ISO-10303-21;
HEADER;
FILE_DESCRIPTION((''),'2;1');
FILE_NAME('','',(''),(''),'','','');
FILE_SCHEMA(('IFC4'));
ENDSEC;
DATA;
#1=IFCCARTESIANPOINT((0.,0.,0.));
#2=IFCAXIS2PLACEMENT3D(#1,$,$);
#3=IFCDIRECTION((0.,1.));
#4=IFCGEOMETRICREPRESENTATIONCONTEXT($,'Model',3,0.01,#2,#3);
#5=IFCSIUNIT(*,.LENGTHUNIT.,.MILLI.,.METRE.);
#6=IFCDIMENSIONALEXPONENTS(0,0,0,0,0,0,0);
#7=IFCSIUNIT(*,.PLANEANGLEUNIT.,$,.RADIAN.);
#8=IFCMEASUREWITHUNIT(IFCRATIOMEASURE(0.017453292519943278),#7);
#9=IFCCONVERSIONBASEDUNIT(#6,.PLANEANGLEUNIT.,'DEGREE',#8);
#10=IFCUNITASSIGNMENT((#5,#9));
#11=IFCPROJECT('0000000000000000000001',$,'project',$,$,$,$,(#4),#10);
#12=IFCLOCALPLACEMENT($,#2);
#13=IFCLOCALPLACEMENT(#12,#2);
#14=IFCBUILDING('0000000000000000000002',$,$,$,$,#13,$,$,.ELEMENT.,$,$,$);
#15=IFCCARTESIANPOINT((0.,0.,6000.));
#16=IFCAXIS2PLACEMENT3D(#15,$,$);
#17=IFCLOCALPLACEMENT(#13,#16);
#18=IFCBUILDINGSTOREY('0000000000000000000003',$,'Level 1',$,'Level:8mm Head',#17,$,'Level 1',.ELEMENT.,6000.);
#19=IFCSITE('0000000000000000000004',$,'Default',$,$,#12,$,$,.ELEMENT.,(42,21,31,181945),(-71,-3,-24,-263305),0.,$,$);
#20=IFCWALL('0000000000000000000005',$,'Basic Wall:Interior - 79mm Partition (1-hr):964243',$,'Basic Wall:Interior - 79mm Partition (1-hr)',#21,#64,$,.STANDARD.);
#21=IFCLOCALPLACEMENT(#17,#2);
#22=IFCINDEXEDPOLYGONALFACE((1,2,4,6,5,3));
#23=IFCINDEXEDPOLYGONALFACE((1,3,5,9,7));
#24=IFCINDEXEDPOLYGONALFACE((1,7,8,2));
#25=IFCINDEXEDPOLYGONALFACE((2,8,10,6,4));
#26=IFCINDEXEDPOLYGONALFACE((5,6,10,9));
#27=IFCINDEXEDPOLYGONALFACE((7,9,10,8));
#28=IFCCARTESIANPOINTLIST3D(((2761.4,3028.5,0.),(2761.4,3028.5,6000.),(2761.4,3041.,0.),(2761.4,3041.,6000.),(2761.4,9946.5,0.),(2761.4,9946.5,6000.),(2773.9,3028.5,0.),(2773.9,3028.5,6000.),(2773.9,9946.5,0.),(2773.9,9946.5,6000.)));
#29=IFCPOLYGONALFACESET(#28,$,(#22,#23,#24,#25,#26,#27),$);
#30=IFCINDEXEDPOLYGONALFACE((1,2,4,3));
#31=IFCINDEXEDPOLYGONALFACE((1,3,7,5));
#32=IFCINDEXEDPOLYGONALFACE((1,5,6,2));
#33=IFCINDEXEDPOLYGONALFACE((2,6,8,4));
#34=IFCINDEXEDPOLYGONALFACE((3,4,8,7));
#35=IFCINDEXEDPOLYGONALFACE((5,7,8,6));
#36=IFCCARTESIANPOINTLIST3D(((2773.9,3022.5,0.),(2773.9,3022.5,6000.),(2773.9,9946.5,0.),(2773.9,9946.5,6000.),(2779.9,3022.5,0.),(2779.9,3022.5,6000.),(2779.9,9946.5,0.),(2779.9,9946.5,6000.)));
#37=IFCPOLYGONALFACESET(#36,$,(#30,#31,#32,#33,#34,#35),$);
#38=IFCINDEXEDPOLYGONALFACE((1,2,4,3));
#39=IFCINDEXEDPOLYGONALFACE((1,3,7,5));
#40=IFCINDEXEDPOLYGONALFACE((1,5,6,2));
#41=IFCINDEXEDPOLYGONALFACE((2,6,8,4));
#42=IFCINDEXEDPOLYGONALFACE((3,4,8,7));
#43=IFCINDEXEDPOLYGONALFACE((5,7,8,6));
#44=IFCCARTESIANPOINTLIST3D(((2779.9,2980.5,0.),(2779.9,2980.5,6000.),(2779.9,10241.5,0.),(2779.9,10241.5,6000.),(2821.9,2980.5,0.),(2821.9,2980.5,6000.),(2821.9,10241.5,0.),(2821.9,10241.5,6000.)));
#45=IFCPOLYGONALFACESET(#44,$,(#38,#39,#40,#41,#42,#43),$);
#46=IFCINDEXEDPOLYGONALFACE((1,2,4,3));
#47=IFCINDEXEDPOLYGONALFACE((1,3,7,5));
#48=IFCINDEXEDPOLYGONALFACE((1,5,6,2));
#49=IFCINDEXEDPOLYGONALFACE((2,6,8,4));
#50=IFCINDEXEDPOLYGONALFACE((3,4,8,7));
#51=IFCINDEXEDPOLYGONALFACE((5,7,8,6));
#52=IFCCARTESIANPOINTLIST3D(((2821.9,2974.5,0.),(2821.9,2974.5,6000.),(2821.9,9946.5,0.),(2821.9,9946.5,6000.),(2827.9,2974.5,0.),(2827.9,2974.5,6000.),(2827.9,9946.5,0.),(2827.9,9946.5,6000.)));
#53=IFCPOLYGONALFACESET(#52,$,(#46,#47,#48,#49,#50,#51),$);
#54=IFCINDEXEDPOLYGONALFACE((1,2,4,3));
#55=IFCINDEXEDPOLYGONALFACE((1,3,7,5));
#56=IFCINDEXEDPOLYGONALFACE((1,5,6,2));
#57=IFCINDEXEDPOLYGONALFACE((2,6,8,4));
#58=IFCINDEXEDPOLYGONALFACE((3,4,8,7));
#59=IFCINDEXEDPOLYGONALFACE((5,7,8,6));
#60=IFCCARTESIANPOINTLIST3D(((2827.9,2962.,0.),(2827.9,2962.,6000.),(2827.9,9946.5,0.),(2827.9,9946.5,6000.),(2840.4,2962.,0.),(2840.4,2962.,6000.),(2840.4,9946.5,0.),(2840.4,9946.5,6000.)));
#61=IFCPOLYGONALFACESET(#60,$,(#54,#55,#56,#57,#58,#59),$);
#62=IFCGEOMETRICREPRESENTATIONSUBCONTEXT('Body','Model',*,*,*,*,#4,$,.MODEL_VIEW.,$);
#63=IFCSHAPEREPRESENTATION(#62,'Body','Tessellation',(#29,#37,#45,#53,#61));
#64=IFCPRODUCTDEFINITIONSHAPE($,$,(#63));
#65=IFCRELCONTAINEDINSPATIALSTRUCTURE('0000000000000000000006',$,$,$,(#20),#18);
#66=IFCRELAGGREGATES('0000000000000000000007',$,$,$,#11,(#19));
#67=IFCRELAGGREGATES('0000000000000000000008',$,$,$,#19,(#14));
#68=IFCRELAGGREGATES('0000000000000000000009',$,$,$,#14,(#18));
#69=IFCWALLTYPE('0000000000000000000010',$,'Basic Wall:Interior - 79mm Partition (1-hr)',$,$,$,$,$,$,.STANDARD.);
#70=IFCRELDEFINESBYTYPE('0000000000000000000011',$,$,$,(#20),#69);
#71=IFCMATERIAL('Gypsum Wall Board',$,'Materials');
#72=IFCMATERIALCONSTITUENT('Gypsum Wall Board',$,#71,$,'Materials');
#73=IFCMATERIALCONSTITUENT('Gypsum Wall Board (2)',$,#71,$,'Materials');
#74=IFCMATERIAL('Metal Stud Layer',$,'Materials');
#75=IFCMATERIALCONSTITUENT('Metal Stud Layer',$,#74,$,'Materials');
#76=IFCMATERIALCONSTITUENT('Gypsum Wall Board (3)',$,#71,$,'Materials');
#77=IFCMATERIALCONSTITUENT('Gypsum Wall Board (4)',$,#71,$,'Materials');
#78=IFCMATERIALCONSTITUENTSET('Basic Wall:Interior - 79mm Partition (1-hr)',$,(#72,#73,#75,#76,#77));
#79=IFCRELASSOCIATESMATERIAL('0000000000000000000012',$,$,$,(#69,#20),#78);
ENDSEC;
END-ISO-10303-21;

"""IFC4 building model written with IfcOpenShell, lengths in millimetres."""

from ifc_helpers import new_model, entity, si_unit, converted_unit, direction, frame, origin, place, context, subcontext, project, spatial, indexed_curve, outline, extrude, material, constituent, constituent_set, type_object, element, save


model = new_model("IFC4")

# Units and contexts
model_context = context("Model", 3, precision=0.01, world=origin(), true_north=direction((0.0, 1.0)))
body_context = subcontext(model_context, "Body", "Model", "MODEL_VIEW")
ifc_project = project(units=[si_unit("LENGTHUNIT", "METRE", prefix="MILLI"), converted_unit("PLANEANGLEUNIT", "DEGREE", entity("IfcRatioMeasure", 0.017453292519943278), si_unit("PLANEANGLEUNIT", "RADIAN"), dimensions=[0, 0, 0, 0, 0, 0, 0])], contexts=[model_context])

# Site, building, storey
site_placement = place(None, origin())
site = spatial("IfcSite", under=ifc_project, at=site_placement, Name="Default", CompositionType="ELEMENT", RefLatitude=(42, 21, 31, 181945), RefLongitude=(-71, -3, -24, -263305), RefElevation=0.0)
building_placement = place(site_placement, origin())
building = spatial("IfcBuilding", under=site, at=building_placement, CompositionType="ELEMENT")
storey_placement = place(building_placement, frame((0.0, 0.0, 6000.0)))
storey = spatial("IfcBuildingStorey", under=building, at=storey_placement, Name="Level 1", ObjectType="Level:8mm Head", LongName="Level 1", CompositionType="ELEMENT", Elevation=6000.0)

# Wall
ifc_material_1 = material(Name="Gypsum Wall Board", Category="Materials")
ifc_constituent_1 = constituent(ifc_material_1, Name="Gypsum Wall Board", Category="Materials")
ifc_constituent_2 = constituent(ifc_material_1, Name="Gypsum Wall Board (2)", Category="Materials")
ifc_material_2 = material(Name="Metal Stud Layer", Category="Materials")
ifc_constituent_3 = constituent(ifc_material_2, Name="Metal Stud Layer", Category="Materials")
ifc_constituent_4 = constituent(ifc_material_1, Name="Gypsum Wall Board (3)", Category="Materials")
ifc_constituent_5 = constituent(ifc_material_1, Name="Gypsum Wall Board (4)", Category="Materials")
ifc_constituent_set_1 = constituent_set(constituents=[ifc_constituent_1, ifc_constituent_2, ifc_constituent_3, ifc_constituent_4, ifc_constituent_5], Name="Basic Wall:Interior - 79mm Partition (1-hr)")
wall_type = type_object("IfcWallType", Name="Basic Wall:Interior - 79mm Partition (1-hr)", PredefinedType="STANDARD", material=ifc_constituent_set_1)
wall_1_placement = place(storey_placement, frame((2800.9, 9946.5, 0.0), z_axis=(0.0, 0.0, 1.0), x_axis=(0.0, -1.0, 0.0)))
element("IfcWall", 1, at=wall_1_placement, inside=storey, type_object=wall_type, material=ifc_constituent_set_1, Name="Basic Wall:Interior - 79mm Partition (1-hr):964243", ObjectType="Basic Wall:Interior - 79mm Partition (1-hr)", PredefinedType="STANDARD", context=body_context, shape_type="SweptSolid", body=[
    extrude(outline(indexed_curve([(2757.2, -5.0), (2769.7, -5.0), (2769.7, 7.5), (-4148.3, 7.5), (-4148.3, -5.0), (2757.2, -5.0)], self_intersect=False)), frame((4148.3, -34.5, 0.0)), (0.0, 0.0, 1.0), 6000.0),
    extrude(outline(indexed_curve([(-3462.0, -3.0), (3462.0, -3.0), (3462.0, 3.0), (-3462.0, 3.0), (-3462.0, -3.0)], self_intersect=False)), frame((3462.0, -24.0, 0.0)), (0.0, 0.0, 1.0), 6000.0),
    extrude(outline(indexed_curve([(-3630.5, -21.0), (3630.5, -21.0), (3630.5, 21.0), (-3630.5, 21.0), (-3630.5, -21.0)], self_intersect=False)), frame((3335.5, 0.0, 0.0)), (0.0, 0.0, 1.0), 6000.0),
    extrude(outline(indexed_curve([(-3486.0, -3.0), (3486.0, -3.0), (3486.0, 3.0), (-3486.0, 3.0), (-3486.0, -3.0)], self_intersect=False)), frame((3486.0, 24.0, 0.0)), (0.0, 0.0, 1.0), 6000.0),
    extrude(outline(indexed_curve([(-6.3, -3492.3), (6.2, -3492.3), (6.3, 3492.3), (-6.2, 3492.3), (-6.3, -3492.3)], self_intersect=False)), frame((3492.3, 33.3, 0.0), z_axis=(0.0, 0.0, 1.0), x_axis=(0.0, -1.0, 0.0)), (0.0, 0.0, 1.0), 6000.0),
])

save(model, "model.ifc")
